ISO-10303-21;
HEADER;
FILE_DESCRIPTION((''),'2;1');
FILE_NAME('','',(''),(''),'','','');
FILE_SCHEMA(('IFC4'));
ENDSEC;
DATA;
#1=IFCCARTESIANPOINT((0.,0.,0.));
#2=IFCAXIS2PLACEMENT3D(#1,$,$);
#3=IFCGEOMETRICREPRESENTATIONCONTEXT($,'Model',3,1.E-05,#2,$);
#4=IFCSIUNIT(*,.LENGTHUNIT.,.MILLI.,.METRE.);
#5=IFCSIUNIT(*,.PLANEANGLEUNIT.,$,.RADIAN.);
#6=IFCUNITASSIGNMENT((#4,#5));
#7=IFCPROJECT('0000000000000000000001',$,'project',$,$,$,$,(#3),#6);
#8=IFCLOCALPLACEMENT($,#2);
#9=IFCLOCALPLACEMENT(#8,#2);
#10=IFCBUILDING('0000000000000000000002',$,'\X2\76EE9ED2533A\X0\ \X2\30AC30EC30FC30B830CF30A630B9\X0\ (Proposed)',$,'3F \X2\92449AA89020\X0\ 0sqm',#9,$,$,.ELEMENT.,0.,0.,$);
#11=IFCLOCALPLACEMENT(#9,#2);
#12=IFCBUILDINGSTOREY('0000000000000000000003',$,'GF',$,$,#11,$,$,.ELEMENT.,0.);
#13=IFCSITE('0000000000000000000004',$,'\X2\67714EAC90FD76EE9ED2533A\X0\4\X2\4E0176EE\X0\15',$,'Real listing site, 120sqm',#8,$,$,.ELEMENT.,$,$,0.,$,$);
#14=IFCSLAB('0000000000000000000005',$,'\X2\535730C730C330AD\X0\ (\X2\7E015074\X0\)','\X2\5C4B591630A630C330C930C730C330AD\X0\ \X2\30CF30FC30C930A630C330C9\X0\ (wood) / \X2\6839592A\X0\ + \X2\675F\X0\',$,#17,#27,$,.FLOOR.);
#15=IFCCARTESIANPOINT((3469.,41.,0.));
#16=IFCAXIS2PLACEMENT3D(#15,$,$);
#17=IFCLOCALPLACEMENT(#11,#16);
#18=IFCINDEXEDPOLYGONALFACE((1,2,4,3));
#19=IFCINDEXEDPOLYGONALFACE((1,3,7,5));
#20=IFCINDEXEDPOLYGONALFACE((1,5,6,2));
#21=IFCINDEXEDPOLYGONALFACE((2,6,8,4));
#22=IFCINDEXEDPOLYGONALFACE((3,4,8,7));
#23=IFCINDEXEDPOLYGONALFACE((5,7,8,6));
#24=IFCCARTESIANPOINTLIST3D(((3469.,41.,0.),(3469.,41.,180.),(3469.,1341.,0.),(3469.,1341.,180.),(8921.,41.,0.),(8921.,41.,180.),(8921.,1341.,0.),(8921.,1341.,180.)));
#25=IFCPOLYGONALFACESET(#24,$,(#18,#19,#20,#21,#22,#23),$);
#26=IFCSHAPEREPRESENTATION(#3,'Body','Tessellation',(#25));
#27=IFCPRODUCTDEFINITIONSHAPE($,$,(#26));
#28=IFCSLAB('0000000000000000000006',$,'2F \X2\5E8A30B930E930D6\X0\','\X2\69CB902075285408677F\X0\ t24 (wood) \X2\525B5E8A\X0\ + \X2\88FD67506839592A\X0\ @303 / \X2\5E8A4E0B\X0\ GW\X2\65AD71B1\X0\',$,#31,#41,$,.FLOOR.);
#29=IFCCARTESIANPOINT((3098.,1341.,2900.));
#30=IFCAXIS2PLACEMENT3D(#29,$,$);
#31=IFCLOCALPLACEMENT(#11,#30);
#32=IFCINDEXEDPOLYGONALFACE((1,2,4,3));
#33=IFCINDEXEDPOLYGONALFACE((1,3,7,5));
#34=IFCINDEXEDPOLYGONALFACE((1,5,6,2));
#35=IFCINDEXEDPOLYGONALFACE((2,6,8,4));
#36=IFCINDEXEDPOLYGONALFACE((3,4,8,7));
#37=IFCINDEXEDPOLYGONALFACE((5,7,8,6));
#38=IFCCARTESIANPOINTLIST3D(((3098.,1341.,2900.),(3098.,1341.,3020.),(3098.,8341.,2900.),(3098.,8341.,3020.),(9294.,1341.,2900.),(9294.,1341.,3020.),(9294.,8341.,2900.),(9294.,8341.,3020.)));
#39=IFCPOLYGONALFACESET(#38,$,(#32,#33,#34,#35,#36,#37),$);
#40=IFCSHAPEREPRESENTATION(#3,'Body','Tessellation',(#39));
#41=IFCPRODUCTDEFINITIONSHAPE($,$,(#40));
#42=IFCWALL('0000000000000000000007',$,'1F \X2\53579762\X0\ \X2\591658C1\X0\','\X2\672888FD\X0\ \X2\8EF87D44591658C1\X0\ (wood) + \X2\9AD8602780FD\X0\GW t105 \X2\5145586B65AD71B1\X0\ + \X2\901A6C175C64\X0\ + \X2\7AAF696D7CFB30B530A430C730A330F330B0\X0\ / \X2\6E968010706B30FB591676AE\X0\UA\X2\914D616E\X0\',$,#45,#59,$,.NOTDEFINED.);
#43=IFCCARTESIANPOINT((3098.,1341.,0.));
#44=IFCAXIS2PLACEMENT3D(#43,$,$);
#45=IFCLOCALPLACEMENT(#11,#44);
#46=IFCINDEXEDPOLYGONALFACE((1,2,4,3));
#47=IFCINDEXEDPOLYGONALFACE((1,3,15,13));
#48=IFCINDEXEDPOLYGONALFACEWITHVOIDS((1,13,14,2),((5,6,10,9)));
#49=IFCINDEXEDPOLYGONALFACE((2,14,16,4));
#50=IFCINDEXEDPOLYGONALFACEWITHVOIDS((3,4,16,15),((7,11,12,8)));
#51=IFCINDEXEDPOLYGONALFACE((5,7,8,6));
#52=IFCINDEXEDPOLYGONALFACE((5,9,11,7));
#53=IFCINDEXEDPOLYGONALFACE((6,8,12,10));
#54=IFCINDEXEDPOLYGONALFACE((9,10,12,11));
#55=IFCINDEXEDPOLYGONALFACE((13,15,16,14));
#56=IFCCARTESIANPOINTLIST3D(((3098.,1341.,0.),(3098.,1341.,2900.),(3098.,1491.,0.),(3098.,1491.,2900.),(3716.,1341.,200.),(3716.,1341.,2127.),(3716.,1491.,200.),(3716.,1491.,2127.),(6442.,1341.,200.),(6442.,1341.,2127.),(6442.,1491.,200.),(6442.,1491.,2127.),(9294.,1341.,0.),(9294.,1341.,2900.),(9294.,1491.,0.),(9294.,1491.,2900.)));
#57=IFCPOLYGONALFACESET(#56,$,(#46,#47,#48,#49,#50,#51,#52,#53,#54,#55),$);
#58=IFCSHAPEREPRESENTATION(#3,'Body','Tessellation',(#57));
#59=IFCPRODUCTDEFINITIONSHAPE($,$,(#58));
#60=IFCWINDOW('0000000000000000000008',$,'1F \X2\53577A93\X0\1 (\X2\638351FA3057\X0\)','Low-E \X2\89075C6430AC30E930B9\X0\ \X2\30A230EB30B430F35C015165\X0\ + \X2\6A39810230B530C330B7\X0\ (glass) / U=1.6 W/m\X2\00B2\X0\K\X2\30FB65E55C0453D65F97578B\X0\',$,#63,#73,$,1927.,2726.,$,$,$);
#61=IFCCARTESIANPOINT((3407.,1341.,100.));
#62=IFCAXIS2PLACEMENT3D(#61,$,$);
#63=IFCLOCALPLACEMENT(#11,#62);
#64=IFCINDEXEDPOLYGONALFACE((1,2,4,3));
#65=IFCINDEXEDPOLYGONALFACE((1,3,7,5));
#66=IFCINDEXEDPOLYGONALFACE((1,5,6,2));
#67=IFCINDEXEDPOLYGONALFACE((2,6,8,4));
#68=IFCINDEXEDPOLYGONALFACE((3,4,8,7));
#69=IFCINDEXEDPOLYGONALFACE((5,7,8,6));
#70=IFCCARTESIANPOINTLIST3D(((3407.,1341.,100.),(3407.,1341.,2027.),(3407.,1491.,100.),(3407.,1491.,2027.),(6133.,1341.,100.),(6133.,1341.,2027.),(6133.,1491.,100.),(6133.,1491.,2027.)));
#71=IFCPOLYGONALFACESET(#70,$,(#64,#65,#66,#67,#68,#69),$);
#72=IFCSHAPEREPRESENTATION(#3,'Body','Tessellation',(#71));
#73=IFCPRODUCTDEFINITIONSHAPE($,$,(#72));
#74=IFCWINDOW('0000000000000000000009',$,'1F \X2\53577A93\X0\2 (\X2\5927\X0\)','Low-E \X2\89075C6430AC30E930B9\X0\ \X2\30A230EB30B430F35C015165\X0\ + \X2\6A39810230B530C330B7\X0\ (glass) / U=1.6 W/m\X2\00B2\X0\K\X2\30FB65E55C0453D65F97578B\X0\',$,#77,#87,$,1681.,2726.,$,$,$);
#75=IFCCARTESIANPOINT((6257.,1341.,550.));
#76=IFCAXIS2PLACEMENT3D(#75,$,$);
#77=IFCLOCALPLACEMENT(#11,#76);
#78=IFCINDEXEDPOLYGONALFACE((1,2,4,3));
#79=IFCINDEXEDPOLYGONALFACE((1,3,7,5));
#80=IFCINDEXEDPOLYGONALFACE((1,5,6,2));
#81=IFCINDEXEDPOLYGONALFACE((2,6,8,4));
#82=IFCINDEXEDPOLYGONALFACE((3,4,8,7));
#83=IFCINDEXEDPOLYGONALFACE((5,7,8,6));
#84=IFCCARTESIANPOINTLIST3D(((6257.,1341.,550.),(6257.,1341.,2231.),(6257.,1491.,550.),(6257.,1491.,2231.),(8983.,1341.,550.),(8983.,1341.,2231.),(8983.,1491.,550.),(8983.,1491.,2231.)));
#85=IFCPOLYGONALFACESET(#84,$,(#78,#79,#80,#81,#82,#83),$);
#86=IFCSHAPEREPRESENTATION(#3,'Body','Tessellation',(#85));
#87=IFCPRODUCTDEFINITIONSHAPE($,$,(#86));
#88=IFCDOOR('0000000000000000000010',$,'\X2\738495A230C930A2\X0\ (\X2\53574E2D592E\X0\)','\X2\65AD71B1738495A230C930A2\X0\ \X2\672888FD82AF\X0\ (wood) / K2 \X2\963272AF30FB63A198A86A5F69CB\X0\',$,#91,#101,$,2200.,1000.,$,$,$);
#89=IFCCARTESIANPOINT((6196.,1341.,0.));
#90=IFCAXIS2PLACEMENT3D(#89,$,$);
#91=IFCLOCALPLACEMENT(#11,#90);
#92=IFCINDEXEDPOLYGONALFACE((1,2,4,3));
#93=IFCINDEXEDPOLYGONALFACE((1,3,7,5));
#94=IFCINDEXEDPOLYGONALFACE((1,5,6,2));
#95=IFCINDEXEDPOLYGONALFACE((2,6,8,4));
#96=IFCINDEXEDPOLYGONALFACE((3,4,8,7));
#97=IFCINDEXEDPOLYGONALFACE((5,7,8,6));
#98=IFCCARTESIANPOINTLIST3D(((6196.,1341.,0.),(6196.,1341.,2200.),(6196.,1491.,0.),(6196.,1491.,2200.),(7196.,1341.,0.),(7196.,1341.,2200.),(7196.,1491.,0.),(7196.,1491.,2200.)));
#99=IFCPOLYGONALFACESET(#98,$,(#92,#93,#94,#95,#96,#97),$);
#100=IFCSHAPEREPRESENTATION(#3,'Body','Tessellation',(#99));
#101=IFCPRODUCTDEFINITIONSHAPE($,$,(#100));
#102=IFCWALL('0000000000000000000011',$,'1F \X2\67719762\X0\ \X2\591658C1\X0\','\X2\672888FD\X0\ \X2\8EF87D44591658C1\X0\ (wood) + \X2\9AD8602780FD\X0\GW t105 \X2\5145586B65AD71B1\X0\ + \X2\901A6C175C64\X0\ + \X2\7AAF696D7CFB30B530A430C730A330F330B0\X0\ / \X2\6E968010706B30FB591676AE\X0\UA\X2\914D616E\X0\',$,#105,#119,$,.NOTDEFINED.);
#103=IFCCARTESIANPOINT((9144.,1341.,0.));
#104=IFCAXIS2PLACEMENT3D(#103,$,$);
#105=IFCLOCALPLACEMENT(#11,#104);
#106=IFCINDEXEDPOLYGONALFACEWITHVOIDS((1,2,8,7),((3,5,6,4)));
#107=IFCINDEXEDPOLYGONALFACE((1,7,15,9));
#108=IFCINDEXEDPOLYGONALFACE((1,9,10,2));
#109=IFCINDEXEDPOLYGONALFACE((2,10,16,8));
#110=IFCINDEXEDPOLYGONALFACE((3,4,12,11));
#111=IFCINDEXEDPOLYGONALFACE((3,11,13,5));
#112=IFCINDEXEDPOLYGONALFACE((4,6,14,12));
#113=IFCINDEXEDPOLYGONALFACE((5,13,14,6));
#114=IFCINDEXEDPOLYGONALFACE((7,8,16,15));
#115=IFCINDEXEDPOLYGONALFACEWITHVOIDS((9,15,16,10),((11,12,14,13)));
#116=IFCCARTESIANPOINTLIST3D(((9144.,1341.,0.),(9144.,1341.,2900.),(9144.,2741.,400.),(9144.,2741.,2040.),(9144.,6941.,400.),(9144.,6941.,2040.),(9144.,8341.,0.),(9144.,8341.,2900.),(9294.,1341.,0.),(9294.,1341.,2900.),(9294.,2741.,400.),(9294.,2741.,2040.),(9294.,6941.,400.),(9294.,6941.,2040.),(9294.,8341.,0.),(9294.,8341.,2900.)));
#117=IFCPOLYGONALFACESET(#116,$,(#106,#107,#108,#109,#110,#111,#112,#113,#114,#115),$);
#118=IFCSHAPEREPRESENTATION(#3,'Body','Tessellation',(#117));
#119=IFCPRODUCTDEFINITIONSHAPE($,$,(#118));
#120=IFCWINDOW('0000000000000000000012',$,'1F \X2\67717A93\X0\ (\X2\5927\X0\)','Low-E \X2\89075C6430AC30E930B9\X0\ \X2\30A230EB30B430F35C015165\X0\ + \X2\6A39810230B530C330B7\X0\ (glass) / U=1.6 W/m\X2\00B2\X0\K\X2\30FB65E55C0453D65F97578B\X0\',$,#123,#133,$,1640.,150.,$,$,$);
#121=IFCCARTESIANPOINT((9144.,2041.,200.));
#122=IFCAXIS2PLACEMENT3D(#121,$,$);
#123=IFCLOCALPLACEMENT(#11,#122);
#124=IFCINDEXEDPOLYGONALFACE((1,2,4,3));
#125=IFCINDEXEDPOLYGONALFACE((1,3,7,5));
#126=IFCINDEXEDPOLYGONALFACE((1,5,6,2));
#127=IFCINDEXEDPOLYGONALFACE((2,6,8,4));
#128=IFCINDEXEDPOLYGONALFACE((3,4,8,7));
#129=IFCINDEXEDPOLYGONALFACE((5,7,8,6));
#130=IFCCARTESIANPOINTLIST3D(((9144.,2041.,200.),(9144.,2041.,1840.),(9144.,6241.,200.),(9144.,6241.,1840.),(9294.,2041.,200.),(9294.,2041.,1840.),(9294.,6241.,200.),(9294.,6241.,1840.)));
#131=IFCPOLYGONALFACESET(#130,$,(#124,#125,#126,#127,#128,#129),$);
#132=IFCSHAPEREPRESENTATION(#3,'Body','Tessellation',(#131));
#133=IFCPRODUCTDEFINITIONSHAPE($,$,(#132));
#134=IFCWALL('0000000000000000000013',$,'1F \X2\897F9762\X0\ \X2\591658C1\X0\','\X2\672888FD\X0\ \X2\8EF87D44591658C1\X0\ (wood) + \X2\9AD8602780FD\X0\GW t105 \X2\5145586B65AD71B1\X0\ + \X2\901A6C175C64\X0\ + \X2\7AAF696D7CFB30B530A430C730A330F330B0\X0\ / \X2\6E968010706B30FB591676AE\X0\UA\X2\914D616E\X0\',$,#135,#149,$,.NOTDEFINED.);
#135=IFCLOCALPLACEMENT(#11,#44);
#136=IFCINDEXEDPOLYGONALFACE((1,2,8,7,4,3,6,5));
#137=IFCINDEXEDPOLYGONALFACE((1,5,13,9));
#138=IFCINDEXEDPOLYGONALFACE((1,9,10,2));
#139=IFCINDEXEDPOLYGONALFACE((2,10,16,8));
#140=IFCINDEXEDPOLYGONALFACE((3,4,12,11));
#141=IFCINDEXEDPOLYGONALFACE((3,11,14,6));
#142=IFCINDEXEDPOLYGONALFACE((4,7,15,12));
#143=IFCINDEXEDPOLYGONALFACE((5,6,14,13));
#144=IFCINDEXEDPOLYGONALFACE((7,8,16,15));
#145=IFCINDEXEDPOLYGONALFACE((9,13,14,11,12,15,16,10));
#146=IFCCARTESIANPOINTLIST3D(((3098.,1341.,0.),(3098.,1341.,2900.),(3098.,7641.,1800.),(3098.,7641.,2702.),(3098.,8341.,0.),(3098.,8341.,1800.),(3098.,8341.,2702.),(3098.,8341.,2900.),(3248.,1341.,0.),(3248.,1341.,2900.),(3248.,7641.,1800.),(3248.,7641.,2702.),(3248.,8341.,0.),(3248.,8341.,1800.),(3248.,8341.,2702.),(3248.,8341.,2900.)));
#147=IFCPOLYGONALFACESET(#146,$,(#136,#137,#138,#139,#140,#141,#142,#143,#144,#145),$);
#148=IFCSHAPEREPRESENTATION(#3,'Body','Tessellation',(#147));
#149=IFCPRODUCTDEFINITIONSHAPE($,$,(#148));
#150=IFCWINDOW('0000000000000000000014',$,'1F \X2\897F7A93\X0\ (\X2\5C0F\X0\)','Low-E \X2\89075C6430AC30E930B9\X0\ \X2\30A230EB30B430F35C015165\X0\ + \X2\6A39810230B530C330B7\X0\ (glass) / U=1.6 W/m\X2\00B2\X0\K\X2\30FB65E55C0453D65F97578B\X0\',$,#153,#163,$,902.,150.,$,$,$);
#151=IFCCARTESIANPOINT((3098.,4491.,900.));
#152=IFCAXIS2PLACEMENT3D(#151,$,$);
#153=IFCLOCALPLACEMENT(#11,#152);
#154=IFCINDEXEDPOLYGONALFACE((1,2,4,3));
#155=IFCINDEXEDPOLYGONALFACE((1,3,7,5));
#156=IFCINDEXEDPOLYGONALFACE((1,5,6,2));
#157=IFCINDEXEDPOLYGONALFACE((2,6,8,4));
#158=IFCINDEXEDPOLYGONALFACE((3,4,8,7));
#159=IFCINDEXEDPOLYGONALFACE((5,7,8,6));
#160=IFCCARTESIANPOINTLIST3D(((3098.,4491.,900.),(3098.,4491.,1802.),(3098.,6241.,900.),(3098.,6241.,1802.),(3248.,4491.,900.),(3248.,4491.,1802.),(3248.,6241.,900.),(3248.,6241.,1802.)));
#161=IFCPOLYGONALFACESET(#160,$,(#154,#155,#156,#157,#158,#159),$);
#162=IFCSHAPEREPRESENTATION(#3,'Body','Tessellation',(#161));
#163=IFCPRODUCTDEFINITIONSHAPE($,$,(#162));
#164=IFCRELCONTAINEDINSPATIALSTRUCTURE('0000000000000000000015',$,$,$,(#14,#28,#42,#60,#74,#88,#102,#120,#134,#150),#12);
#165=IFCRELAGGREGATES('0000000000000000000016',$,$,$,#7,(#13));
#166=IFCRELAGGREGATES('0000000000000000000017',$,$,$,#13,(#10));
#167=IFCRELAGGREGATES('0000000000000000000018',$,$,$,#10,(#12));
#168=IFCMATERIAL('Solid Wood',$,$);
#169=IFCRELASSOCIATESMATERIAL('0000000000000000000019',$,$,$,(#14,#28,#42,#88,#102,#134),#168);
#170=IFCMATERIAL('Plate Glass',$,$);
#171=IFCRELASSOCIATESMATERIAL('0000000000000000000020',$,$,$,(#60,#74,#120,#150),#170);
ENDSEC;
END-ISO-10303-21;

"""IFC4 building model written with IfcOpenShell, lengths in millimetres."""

from ifc_helpers import new_model, si_unit, frame, frame_2d, origin, place, context, project, spatial, rectangle, extrude, material, element, fill, save


model = new_model("IFC4")

# Units and contexts
model_context = context("Model", 3, precision=1e-05, world=origin())
ifc_project = project(units=[si_unit("LENGTHUNIT", "METRE", prefix="MILLI"), si_unit("PLANEANGLEUNIT", "RADIAN")], contexts=[model_context])

# Site, building, storey
site_placement = place(None, origin())
site = spatial("IfcSite", under=ifc_project, at=site_placement, Name="東京都目黒区4丁目15", ObjectType="Real listing site, 120sqm", CompositionType="ELEMENT", RefElevation=0.0)
building_placement = place(site_placement, origin())
building = spatial("IfcBuilding", under=site, at=building_placement, Name="目黒区 ガレージハウス (Proposed)", ObjectType="3F 鉄骨造 0sqm", CompositionType="ELEMENT", ElevationOfRefHeight=0.0, ElevationOfTerrain=0.0)
storey_placement = place(building_placement, origin())
storey = spatial("IfcBuildingStorey", under=building, at=storey_placement, Name="GF", CompositionType="ELEMENT", Elevation=0.0)

# Slabs
ifc_material_1 = material(Name="Solid Wood")
slab_1_placement = place(storey_placement, frame((3469.0, 41.0, 0.0)))
element("IfcSlab", 1, at=slab_1_placement, inside=storey, material=ifc_material_1, Name="南デッキ (縁側)", Description="屋外ウッドデッキ ハードウッド (wood) / 根太 + 束", PredefinedType="FLOOR", context=model_context, shape_type="SweptSolid", body=[
    extrude(rectangle(XDim=5452.0, YDim=1300.0, at=frame_2d((2726.0, 650.0))), frame((3469.0, 41.0, 0.0)), (0.0, 0.0, 1.0), 180.0),
])
slab_2_placement = place(storey_placement, frame((3098.0, 1341.0, 2900.0)))
element("IfcSlab", 2, at=slab_2_placement, inside=storey, material=ifc_material_1, Name="2F 床スラブ", Description="構造用合板 t24 (wood) 剛床 + 製材根太 @303 / 床下 GW断熱", PredefinedType="FLOOR", context=model_context, shape_type="SweptSolid", body=[
    extrude(rectangle(XDim=6196.0, YDim=7000.0, at=frame_2d((3098.0, 3500.0))), frame((3098.0, 1341.0, 2900.0)), (0.0, 0.0, 1.0), 120.0),
])

# Wall, openings, windows, door
wall_1_placement = place(storey_placement, frame((3098.0, 1341.0, 0.0)))
wall_1 = element("IfcWall", 3, at=wall_1_placement, inside=storey, material=ifc_material_1, Name="1F 南面 外壁", Description="木製 軸組外壁 (wood) + 高性能GW t105 充填断熱 + 通気層 + 窯業系サイディング / 準耐火・外皮UA配慮", PredefinedType="NOTDEFINED", context=model_context, shape_type="SweptSolid", body=[
    extrude(rectangle(XDim=6196.0, YDim=150.0, at=frame_2d((3098.0, 75.0))), frame((3098.0, 1341.0, 0.0)), (0.0, 0.0, 1.0), 2900.0),
])
opening_1_placement = place(storey_placement, frame((3407.0, 1341.0, 100.0)))
opening_1 = element("IfcOpeningElement", 4, at=opening_1_placement, cuts=wall_1, PredefinedType="NOTDEFINED", context=model_context, shape_type="SweptSolid", body=[
    extrude(rectangle(XDim=2726.0, YDim=150.0, at=frame_2d((1363.0, 75.0))), frame((3407.0, 1341.0, 100.0)), (0.0, 0.0, 1.0), 1927.0),
])
opening_2_placement = place(storey_placement, frame((6257.0, 1341.0, 550.0)))
opening_2 = element("IfcOpeningElement", 5, at=opening_2_placement, cuts=wall_1, PredefinedType="NOTDEFINED", context=model_context, shape_type="SweptSolid", body=[
    extrude(rectangle(XDim=2726.0, YDim=150.0, at=frame_2d((1363.0, 75.0))), frame((6257.0, 1341.0, 550.0)), (0.0, 0.0, 1.0), 1681.0),
])
opening_3_placement = place(storey_placement, frame((6196.0, 1341.0, 0.0)))
opening_3 = element("IfcOpeningElement", 6, at=opening_3_placement, cuts=wall_1, PredefinedType="NOTDEFINED", context=model_context, shape_type="SweptSolid", body=[
    extrude(rectangle(XDim=1000.0, YDim=150.0, at=frame_2d((500.0, 75.0))), frame((6196.0, 1341.0, 0.0)), (0.0, 0.0, 1.0), 2200.0),
])
ifc_material_2 = material(Name="Plate Glass")
window_1_placement = place(storey_placement, frame((3407.0, 1341.0, 100.0)))
window_1 = element("IfcWindow", 7, at=window_1_placement, inside=storey, material=ifc_material_2, Name="1F 南窓1 (掃出し)", Description="Low-E 複層ガラス アルゴン封入 + 樹脂サッシ (glass) / U=1.6 W/m²K・日射取得型", OverallHeight=1927.0, OverallWidth=2726.0, context=model_context, shape_type="SweptSolid", body=[
    extrude(rectangle(XDim=2726.0, YDim=150.0, at=frame_2d((1363.0, 75.0))), frame((3407.0, 1341.0, 100.0)), (0.0, 0.0, 1.0), 1927.0),
])
fill(opening_1, window_1)
window_2_placement = place(storey_placement, frame((6257.0, 1341.0, 550.0)))
window_2 = element("IfcWindow", 8, at=window_2_placement, inside=storey, material=ifc_material_2, Name="1F 南窓2 (大)", Description="Low-E 複層ガラス アルゴン封入 + 樹脂サッシ (glass) / U=1.6 W/m²K・日射取得型", OverallHeight=1681.0, OverallWidth=2726.0, context=model_context, shape_type="SweptSolid", body=[
    extrude(rectangle(XDim=2726.0, YDim=150.0, at=frame_2d((1363.0, 75.0))), frame((6257.0, 1341.0, 550.0)), (0.0, 0.0, 1.0), 1681.0),
])
fill(opening_2, window_2)
door_placement = place(storey_placement, frame((6196.0, 1341.0, 0.0)))
door = element("IfcDoor", 9, at=door_placement, inside=storey, material=ifc_material_1, Name="玄関ドア (南中央)", Description="断熱玄関ドア 木製芯 (wood) / K2 防犯・採風機構", OverallHeight=2200.0, OverallWidth=1000.0, context=model_context, shape_type="SweptSolid", body=[
    extrude(rectangle(XDim=1000.0, YDim=150.0, at=frame_2d((500.0, 75.0))), frame((6196.0, 1341.0, 0.0)), (0.0, 0.0, 1.0), 2200.0),
])
fill(opening_3, door)

# Walls, openings, windows
wall_2_placement = place(storey_placement, frame((9144.0, 1341.0, 0.0)))
wall_2 = element("IfcWall", 10, at=wall_2_placement, inside=storey, material=ifc_material_1, Name="1F 東面 外壁", Description="木製 軸組外壁 (wood) + 高性能GW t105 充填断熱 + 通気層 + 窯業系サイディング / 準耐火・外皮UA配慮", PredefinedType="NOTDEFINED", context=model_context, shape_type="SweptSolid", body=[
    extrude(rectangle(XDim=150.0, YDim=7000.0, at=frame_2d((75.0, 3500.0))), frame((9144.0, 1341.0, 0.0)), (0.0, 0.0, 1.0), 2900.0),
])
opening_4_placement = place(storey_placement, frame((9144.0, 2041.0, 200.0)))
opening_4 = element("IfcOpeningElement", 11, at=opening_4_placement, cuts=wall_2, PredefinedType="NOTDEFINED", context=model_context, shape_type="SweptSolid", body=[
    extrude(rectangle(XDim=150.0, YDim=4200.0, at=frame_2d((75.0, 2100.0))), frame((9144.0, 2041.0, 200.0)), (0.0, 0.0, 1.0), 1640.0),
])
window_3_placement = place(storey_placement, frame((9144.0, 2041.0, 200.0)))
window_3 = element("IfcWindow", 12, at=window_3_placement, inside=storey, material=ifc_material_2, Name="1F 東窓 (大)", Description="Low-E 複層ガラス アルゴン封入 + 樹脂サッシ (glass) / U=1.6 W/m²K・日射取得型", OverallHeight=1640.0, OverallWidth=150.0, context=model_context, shape_type="SweptSolid", body=[
    extrude(rectangle(XDim=150.0, YDim=4200.0, at=frame_2d((75.0, 2100.0))), frame((9144.0, 2041.0, 200.0)), (0.0, 0.0, 1.0), 1640.0),
])
fill(opening_4, window_3)
wall_3_placement = place(storey_placement, frame((3098.0, 1341.0, 0.0)))
wall_3 = element("IfcWall", 13, at=wall_3_placement, inside=storey, material=ifc_material_1, Name="1F 西面 外壁", Description="木製 軸組外壁 (wood) + 高性能GW t105 充填断熱 + 通気層 + 窯業系サイディング / 準耐火・外皮UA配慮", PredefinedType="NOTDEFINED", context=model_context, shape_type="SweptSolid", body=[
    extrude(rectangle(XDim=150.0, YDim=7000.0, at=frame_2d((75.0, 3500.0))), frame((3098.0, 1341.0, 0.0)), (0.0, 0.0, 1.0), 2900.0),
])
opening_5_placement = place(storey_placement, frame((3098.0, 4491.0, 900.0)))
opening_5 = element("IfcOpeningElement", 14, at=opening_5_placement, cuts=wall_3, PredefinedType="NOTDEFINED", context=model_context, shape_type="SweptSolid", body=[
    extrude(rectangle(XDim=150.0, YDim=1750.0, at=frame_2d((75.0, 875.0))), frame((3098.0, 4491.0, 900.0)), (0.0, 0.0, 1.0), 902.0),
])
window_4_placement = place(storey_placement, frame((3098.0, 4491.0, 900.0)))
window_4 = element("IfcWindow", 15, at=window_4_placement, inside=storey, material=ifc_material_2, Name="1F 西窓 (小)", Description="Low-E 複層ガラス アルゴン封入 + 樹脂サッシ (glass) / U=1.6 W/m²K・日射取得型", OverallHeight=902.0, OverallWidth=150.0, context=model_context, shape_type="SweptSolid", body=[
    extrude(rectangle(XDim=150.0, YDim=1750.0, at=frame_2d((75.0, 875.0))), frame((3098.0, 4491.0, 900.0)), (0.0, 0.0, 1.0), 902.0),
])
fill(opening_5, window_4)

save(model, "model.ifc")
